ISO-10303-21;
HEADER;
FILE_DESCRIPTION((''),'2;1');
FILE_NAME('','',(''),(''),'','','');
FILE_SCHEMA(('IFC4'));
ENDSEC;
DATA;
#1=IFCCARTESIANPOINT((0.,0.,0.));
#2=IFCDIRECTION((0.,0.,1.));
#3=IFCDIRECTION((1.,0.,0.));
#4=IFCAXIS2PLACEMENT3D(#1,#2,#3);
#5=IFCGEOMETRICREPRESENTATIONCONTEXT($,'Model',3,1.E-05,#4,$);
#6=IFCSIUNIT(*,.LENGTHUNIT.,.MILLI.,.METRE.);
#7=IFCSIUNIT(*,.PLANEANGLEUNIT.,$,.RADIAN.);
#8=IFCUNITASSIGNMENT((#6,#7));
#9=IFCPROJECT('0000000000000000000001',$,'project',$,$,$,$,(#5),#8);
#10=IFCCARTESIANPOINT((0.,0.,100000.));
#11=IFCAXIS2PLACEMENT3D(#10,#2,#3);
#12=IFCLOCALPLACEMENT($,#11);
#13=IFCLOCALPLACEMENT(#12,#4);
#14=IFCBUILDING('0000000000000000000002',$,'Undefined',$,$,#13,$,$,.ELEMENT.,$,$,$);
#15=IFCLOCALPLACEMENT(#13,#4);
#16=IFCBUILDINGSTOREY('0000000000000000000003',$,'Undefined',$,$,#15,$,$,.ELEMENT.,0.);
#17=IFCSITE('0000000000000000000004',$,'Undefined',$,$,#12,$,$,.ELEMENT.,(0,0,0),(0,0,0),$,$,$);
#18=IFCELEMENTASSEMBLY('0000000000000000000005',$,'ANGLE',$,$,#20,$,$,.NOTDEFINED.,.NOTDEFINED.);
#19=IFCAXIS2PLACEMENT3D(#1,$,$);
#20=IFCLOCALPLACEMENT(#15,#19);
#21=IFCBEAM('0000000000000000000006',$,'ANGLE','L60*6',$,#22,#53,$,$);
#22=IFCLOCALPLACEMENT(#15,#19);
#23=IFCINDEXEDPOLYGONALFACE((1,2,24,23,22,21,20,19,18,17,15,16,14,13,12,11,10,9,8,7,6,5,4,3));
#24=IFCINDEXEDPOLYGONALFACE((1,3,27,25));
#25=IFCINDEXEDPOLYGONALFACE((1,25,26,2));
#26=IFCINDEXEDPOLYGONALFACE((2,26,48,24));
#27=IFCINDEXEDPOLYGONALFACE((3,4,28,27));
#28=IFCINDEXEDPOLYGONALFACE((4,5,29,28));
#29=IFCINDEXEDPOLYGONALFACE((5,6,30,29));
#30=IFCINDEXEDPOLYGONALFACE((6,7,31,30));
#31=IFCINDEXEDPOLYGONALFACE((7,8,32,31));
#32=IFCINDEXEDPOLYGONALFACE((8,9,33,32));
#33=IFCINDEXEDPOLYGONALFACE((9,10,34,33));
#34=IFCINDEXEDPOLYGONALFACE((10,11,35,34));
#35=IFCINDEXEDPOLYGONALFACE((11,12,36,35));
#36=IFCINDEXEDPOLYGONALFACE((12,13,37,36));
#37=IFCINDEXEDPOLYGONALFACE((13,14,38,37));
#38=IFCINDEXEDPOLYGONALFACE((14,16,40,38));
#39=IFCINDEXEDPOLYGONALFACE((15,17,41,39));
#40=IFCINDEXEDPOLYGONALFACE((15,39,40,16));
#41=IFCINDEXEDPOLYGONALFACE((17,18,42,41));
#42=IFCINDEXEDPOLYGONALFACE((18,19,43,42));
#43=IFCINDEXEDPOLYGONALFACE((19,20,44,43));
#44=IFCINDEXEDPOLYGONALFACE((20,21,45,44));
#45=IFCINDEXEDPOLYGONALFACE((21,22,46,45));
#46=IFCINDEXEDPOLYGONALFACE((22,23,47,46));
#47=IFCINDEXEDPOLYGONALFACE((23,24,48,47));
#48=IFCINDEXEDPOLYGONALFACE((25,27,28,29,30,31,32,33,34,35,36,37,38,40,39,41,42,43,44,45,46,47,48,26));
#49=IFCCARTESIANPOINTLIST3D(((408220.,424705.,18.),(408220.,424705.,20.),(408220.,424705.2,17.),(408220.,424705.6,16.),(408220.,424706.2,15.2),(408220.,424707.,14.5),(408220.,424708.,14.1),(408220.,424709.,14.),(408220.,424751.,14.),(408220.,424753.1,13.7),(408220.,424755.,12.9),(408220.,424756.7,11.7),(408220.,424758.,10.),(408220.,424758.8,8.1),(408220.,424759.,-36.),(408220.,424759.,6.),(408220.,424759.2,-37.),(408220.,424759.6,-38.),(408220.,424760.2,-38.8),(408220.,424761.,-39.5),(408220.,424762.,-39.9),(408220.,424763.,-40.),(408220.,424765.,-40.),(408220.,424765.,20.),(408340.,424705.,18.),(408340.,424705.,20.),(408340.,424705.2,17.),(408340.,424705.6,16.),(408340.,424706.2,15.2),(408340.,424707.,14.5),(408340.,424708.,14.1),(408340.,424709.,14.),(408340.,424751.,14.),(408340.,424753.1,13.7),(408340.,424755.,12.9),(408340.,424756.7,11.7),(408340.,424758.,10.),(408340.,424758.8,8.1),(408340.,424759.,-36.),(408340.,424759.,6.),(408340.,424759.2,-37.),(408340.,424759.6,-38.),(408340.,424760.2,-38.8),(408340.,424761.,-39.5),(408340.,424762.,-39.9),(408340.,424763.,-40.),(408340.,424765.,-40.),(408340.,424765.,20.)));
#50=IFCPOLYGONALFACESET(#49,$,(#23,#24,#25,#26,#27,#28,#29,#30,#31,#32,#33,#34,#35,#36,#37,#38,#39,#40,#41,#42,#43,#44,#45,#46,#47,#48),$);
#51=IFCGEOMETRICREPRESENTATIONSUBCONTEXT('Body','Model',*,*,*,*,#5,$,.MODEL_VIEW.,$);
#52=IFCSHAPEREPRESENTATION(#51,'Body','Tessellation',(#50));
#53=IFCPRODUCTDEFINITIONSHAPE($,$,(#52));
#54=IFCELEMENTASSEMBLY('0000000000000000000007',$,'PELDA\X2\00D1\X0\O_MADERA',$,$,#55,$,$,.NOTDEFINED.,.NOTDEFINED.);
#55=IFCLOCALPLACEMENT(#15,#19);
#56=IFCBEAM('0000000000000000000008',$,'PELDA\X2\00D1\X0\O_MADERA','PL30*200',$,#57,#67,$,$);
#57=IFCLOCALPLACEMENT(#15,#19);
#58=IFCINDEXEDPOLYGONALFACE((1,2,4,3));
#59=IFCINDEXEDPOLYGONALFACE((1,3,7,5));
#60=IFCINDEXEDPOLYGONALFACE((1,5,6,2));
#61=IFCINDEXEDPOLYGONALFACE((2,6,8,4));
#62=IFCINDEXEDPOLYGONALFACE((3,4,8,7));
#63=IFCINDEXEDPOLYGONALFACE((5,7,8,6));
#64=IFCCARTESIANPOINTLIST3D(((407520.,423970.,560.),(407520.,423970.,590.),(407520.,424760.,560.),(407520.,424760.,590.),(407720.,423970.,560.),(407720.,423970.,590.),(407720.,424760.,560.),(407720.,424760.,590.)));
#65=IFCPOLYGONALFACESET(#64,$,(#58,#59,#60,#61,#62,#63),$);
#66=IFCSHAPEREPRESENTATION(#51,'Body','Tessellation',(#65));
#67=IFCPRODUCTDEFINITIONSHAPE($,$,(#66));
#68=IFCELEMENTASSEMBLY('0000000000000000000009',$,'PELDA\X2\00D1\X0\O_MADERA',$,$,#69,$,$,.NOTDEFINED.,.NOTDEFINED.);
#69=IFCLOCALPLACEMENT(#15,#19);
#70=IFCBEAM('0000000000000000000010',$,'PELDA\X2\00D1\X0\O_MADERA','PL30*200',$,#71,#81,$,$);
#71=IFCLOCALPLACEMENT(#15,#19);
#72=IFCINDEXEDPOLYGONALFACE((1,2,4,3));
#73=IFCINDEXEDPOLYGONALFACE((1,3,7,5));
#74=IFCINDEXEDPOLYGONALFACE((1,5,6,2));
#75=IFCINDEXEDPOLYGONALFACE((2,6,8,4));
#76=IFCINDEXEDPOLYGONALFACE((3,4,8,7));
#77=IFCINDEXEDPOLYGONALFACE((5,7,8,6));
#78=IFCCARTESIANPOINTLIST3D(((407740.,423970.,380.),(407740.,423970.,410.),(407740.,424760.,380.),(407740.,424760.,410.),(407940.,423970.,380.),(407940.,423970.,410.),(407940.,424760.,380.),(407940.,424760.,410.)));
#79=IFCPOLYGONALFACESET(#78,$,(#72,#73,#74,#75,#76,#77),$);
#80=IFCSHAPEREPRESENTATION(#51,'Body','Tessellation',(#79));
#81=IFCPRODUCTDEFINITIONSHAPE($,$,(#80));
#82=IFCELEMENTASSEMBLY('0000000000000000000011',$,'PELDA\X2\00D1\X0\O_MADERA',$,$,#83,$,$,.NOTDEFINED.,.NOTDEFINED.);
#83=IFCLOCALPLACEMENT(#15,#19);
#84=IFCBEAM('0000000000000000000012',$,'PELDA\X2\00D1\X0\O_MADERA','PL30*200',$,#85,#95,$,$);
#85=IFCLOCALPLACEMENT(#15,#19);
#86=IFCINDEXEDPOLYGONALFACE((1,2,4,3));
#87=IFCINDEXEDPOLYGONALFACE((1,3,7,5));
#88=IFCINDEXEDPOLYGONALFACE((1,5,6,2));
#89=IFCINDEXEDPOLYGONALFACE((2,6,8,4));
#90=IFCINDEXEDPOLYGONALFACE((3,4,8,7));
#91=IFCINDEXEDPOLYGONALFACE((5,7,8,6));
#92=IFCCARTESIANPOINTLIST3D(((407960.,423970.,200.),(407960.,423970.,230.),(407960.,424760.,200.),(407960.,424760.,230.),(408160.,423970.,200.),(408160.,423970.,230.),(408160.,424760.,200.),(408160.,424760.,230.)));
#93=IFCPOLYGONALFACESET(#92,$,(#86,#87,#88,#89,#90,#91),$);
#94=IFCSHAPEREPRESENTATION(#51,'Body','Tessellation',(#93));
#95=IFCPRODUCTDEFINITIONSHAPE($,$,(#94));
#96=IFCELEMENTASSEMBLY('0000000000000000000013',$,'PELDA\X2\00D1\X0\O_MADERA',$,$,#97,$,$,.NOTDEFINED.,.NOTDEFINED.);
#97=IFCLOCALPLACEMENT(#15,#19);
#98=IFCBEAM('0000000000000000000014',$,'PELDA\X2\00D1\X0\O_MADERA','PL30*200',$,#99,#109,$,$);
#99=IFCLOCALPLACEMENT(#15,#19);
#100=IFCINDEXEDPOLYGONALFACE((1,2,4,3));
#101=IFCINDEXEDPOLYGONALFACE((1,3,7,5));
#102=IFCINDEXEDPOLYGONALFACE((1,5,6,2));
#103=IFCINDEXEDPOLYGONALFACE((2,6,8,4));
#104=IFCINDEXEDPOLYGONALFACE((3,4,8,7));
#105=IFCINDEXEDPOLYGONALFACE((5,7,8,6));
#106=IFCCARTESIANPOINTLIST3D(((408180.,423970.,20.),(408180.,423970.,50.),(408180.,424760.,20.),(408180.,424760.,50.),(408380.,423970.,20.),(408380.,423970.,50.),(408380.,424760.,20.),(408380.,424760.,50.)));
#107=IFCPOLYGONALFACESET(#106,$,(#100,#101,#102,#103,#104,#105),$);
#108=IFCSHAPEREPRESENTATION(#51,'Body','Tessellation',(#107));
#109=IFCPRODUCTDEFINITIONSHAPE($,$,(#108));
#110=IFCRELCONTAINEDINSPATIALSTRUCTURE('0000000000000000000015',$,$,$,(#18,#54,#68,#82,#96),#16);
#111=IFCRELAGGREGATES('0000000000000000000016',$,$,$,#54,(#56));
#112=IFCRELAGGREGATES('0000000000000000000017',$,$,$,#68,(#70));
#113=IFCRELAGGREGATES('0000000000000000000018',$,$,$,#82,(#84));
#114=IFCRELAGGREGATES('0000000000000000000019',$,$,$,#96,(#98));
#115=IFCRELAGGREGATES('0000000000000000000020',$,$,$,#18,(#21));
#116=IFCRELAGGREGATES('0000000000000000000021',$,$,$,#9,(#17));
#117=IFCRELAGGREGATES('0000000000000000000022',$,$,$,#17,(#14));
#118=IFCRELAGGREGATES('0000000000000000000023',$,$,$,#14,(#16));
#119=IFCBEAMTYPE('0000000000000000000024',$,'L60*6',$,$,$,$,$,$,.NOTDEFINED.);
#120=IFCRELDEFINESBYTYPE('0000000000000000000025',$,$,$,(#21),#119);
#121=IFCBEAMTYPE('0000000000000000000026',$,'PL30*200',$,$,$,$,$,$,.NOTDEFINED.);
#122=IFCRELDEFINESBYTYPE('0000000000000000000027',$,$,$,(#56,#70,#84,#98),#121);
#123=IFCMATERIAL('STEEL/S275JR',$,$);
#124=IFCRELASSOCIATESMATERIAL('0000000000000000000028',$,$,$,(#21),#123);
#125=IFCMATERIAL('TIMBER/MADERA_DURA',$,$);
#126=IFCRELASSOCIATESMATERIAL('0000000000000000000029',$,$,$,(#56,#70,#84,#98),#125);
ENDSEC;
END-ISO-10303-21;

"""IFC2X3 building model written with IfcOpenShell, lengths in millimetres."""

from ifc_helpers import new_model, si_unit, frame, origin_with_axes, origin_2d_with_axis, place, context, subcontext, project, spatial, rectangle, l_section, extrude, material, type_object, element, aggregate, save


model = new_model("IFC2X3")

# Units and contexts
model_context = context("Model", 3, precision=1e-05, world=origin_with_axes())
body_context = subcontext(model_context, "Body", "Model", "MODEL_VIEW")
ifc_project = project(units=[si_unit("LENGTHUNIT", "METRE", prefix="MILLI"), si_unit("PLANEANGLEUNIT", "RADIAN")], contexts=[model_context])

# Site, building, storey
site_placement = place(None, frame((0.0, 0.0, 100000.0), z_axis=(0.0, 0.0, 1.0), x_axis=(1.0, 0.0, 0.0)))
site = spatial("IfcSite", under=ifc_project, at=site_placement, Name="Undefined", CompositionType="ELEMENT", RefLatitude=(0, 0, 0), RefLongitude=(0, 0, 0))
building_placement = place(site_placement, origin_with_axes())
building = spatial("IfcBuilding", under=site, at=building_placement, Name="Undefined", CompositionType="ELEMENT")
storey_placement = place(building_placement, origin_with_axes())
storey = spatial("IfcBuildingStorey", under=building, at=storey_placement, Name="Undefined", CompositionType="ELEMENT", Elevation=0.0)

# Shared definitions
ifc_material_1 = material(Name="STEEL/S275JR")

# Element assemblies, beams
beam_type_1 = type_object("IfcBeamType", Name="L60*6", PredefinedType="NOTDEFINED")
assembly_1_placement = place(storey_placement, origin_with_axes())
assembly_1 = element("IfcElementAssembly", 1, at=assembly_1_placement, inside=storey, Name="ANGLE", AssemblyPlace="NOTDEFINED", PredefinedType="NOTDEFINED")
beam_1_placement = place(assembly_1_placement, frame((408220.0, 424735.0, -10.0), z_axis=(0.0, -1.0, 0.0), x_axis=(1.0, 0.0, 0.0)))
beam_1 = element("IfcBeam", 2, at=beam_1_placement, type_object=beam_type_1, material=ifc_material_1, Name="ANGLE", Description="L60*6", context=body_context, shape_type="SweptSolid", body=[
    extrude(l_section(Depth=60.0, Width=60.0, Thickness=6.0, FilletRadius=8.0, EdgeRadius=4.0, at=origin_2d_with_axis()), frame((120.0, 0.0, 0.0), z_axis=(-1.0, 0.0, 0.0), x_axis=(0.0, -1.0, 0.0)), (0.0, 0.0, 1.0), 120.0),
])
assembly_2_placement = place(storey_placement, origin_with_axes())
assembly_2 = element("IfcElementAssembly", 3, at=assembly_2_placement, inside=storey, Name="PELDAÑO_MADERA", AssemblyPlace="NOTDEFINED", PredefinedType="NOTDEFINED")
ifc_material_2 = material(Name="TIMBER/MADERA_DURA")
beam_type_2 = type_object("IfcBeamType", Name="PL30*200", PredefinedType="NOTDEFINED")
beam_2_placement = place(assembly_2_placement, frame((407620.0, 424760.0, 575.0), z_axis=(-1.0, 0.0, 0.0), x_axis=(0.0, -1.0, 0.0)))
beam_2 = element("IfcBeam", 4, at=beam_2_placement, type_object=beam_type_2, material=ifc_material_2, Name="PELDAÑO_MADERA", Description="PL30*200", context=body_context, shape_type="SweptSolid", body=[
    extrude(rectangle(XDim=30.0, YDim=200.0, at=origin_2d_with_axis()), frame((790.0, 0.0, 0.0), z_axis=(-1.0, 0.0, 0.0), x_axis=(0.0, -1.0, 0.0)), (0.0, 0.0, 1.0), 790.0),
])
aggregate(assembly_2, [beam_2])
assembly_3_placement = place(storey_placement, origin_with_axes())
assembly_3 = element("IfcElementAssembly", 5, at=assembly_3_placement, inside=storey, Name="PELDAÑO_MADERA", AssemblyPlace="NOTDEFINED", PredefinedType="NOTDEFINED")
beam_3_placement = place(assembly_3_placement, frame((407840.0, 424760.0, 395.0), z_axis=(-1.0, 0.0, 0.0), x_axis=(0.0, -1.0, 0.0)))
beam_3 = element("IfcBeam", 6, at=beam_3_placement, type_object=beam_type_2, material=ifc_material_2, Name="PELDAÑO_MADERA", Description="PL30*200", context=body_context, shape_type="SweptSolid", body=[
    extrude(rectangle(XDim=30.0, YDim=200.0, at=origin_2d_with_axis()), frame((790.0, 0.0, 0.0), z_axis=(-1.0, 0.0, 0.0), x_axis=(0.0, -1.0, 0.0)), (0.0, 0.0, 1.0), 790.0),
])
aggregate(assembly_3, [beam_3])
assembly_4_placement = place(storey_placement, origin_with_axes())
assembly_4 = element("IfcElementAssembly", 7, at=assembly_4_placement, inside=storey, Name="PELDAÑO_MADERA", AssemblyPlace="NOTDEFINED", PredefinedType="NOTDEFINED")
beam_4_placement = place(assembly_4_placement, frame((408060.0, 424760.0, 215.0), z_axis=(-1.0, 0.0, 0.0), x_axis=(0.0, -1.0, 0.0)))
beam_4 = element("IfcBeam", 8, at=beam_4_placement, type_object=beam_type_2, material=ifc_material_2, Name="PELDAÑO_MADERA", Description="PL30*200", context=body_context, shape_type="SweptSolid", body=[
    extrude(rectangle(XDim=30.0, YDim=200.0, at=origin_2d_with_axis()), frame((790.0, 0.0, 0.0), z_axis=(-1.0, 0.0, 0.0), x_axis=(0.0, -1.0, 0.0)), (0.0, 0.0, 1.0), 790.0),
])
aggregate(assembly_4, [beam_4])
assembly_5_placement = place(storey_placement, origin_with_axes())
assembly_5 = element("IfcElementAssembly", 9, at=assembly_5_placement, inside=storey, Name="PELDAÑO_MADERA", AssemblyPlace="NOTDEFINED", PredefinedType="NOTDEFINED")
beam_5_placement = place(assembly_5_placement, frame((408280.0, 424760.0, 35.0), z_axis=(-1.0, 0.0, 0.0), x_axis=(0.0, -1.0, 0.0)))
beam_5 = element("IfcBeam", 10, at=beam_5_placement, type_object=beam_type_2, material=ifc_material_2, Name="PELDAÑO_MADERA", Description="PL30*200", context=body_context, shape_type="SweptSolid", body=[
    extrude(rectangle(XDim=30.0, YDim=200.0, at=origin_2d_with_axis()), frame((790.0, 0.0, 0.0), z_axis=(-1.0, 0.0, 0.0), x_axis=(0.0, -1.0, 0.0)), (0.0, 0.0, 1.0), 790.0),
])
aggregate(assembly_5, [beam_5])

aggregate(assembly_1, [beam_1])

save(model, "model.ifc")
